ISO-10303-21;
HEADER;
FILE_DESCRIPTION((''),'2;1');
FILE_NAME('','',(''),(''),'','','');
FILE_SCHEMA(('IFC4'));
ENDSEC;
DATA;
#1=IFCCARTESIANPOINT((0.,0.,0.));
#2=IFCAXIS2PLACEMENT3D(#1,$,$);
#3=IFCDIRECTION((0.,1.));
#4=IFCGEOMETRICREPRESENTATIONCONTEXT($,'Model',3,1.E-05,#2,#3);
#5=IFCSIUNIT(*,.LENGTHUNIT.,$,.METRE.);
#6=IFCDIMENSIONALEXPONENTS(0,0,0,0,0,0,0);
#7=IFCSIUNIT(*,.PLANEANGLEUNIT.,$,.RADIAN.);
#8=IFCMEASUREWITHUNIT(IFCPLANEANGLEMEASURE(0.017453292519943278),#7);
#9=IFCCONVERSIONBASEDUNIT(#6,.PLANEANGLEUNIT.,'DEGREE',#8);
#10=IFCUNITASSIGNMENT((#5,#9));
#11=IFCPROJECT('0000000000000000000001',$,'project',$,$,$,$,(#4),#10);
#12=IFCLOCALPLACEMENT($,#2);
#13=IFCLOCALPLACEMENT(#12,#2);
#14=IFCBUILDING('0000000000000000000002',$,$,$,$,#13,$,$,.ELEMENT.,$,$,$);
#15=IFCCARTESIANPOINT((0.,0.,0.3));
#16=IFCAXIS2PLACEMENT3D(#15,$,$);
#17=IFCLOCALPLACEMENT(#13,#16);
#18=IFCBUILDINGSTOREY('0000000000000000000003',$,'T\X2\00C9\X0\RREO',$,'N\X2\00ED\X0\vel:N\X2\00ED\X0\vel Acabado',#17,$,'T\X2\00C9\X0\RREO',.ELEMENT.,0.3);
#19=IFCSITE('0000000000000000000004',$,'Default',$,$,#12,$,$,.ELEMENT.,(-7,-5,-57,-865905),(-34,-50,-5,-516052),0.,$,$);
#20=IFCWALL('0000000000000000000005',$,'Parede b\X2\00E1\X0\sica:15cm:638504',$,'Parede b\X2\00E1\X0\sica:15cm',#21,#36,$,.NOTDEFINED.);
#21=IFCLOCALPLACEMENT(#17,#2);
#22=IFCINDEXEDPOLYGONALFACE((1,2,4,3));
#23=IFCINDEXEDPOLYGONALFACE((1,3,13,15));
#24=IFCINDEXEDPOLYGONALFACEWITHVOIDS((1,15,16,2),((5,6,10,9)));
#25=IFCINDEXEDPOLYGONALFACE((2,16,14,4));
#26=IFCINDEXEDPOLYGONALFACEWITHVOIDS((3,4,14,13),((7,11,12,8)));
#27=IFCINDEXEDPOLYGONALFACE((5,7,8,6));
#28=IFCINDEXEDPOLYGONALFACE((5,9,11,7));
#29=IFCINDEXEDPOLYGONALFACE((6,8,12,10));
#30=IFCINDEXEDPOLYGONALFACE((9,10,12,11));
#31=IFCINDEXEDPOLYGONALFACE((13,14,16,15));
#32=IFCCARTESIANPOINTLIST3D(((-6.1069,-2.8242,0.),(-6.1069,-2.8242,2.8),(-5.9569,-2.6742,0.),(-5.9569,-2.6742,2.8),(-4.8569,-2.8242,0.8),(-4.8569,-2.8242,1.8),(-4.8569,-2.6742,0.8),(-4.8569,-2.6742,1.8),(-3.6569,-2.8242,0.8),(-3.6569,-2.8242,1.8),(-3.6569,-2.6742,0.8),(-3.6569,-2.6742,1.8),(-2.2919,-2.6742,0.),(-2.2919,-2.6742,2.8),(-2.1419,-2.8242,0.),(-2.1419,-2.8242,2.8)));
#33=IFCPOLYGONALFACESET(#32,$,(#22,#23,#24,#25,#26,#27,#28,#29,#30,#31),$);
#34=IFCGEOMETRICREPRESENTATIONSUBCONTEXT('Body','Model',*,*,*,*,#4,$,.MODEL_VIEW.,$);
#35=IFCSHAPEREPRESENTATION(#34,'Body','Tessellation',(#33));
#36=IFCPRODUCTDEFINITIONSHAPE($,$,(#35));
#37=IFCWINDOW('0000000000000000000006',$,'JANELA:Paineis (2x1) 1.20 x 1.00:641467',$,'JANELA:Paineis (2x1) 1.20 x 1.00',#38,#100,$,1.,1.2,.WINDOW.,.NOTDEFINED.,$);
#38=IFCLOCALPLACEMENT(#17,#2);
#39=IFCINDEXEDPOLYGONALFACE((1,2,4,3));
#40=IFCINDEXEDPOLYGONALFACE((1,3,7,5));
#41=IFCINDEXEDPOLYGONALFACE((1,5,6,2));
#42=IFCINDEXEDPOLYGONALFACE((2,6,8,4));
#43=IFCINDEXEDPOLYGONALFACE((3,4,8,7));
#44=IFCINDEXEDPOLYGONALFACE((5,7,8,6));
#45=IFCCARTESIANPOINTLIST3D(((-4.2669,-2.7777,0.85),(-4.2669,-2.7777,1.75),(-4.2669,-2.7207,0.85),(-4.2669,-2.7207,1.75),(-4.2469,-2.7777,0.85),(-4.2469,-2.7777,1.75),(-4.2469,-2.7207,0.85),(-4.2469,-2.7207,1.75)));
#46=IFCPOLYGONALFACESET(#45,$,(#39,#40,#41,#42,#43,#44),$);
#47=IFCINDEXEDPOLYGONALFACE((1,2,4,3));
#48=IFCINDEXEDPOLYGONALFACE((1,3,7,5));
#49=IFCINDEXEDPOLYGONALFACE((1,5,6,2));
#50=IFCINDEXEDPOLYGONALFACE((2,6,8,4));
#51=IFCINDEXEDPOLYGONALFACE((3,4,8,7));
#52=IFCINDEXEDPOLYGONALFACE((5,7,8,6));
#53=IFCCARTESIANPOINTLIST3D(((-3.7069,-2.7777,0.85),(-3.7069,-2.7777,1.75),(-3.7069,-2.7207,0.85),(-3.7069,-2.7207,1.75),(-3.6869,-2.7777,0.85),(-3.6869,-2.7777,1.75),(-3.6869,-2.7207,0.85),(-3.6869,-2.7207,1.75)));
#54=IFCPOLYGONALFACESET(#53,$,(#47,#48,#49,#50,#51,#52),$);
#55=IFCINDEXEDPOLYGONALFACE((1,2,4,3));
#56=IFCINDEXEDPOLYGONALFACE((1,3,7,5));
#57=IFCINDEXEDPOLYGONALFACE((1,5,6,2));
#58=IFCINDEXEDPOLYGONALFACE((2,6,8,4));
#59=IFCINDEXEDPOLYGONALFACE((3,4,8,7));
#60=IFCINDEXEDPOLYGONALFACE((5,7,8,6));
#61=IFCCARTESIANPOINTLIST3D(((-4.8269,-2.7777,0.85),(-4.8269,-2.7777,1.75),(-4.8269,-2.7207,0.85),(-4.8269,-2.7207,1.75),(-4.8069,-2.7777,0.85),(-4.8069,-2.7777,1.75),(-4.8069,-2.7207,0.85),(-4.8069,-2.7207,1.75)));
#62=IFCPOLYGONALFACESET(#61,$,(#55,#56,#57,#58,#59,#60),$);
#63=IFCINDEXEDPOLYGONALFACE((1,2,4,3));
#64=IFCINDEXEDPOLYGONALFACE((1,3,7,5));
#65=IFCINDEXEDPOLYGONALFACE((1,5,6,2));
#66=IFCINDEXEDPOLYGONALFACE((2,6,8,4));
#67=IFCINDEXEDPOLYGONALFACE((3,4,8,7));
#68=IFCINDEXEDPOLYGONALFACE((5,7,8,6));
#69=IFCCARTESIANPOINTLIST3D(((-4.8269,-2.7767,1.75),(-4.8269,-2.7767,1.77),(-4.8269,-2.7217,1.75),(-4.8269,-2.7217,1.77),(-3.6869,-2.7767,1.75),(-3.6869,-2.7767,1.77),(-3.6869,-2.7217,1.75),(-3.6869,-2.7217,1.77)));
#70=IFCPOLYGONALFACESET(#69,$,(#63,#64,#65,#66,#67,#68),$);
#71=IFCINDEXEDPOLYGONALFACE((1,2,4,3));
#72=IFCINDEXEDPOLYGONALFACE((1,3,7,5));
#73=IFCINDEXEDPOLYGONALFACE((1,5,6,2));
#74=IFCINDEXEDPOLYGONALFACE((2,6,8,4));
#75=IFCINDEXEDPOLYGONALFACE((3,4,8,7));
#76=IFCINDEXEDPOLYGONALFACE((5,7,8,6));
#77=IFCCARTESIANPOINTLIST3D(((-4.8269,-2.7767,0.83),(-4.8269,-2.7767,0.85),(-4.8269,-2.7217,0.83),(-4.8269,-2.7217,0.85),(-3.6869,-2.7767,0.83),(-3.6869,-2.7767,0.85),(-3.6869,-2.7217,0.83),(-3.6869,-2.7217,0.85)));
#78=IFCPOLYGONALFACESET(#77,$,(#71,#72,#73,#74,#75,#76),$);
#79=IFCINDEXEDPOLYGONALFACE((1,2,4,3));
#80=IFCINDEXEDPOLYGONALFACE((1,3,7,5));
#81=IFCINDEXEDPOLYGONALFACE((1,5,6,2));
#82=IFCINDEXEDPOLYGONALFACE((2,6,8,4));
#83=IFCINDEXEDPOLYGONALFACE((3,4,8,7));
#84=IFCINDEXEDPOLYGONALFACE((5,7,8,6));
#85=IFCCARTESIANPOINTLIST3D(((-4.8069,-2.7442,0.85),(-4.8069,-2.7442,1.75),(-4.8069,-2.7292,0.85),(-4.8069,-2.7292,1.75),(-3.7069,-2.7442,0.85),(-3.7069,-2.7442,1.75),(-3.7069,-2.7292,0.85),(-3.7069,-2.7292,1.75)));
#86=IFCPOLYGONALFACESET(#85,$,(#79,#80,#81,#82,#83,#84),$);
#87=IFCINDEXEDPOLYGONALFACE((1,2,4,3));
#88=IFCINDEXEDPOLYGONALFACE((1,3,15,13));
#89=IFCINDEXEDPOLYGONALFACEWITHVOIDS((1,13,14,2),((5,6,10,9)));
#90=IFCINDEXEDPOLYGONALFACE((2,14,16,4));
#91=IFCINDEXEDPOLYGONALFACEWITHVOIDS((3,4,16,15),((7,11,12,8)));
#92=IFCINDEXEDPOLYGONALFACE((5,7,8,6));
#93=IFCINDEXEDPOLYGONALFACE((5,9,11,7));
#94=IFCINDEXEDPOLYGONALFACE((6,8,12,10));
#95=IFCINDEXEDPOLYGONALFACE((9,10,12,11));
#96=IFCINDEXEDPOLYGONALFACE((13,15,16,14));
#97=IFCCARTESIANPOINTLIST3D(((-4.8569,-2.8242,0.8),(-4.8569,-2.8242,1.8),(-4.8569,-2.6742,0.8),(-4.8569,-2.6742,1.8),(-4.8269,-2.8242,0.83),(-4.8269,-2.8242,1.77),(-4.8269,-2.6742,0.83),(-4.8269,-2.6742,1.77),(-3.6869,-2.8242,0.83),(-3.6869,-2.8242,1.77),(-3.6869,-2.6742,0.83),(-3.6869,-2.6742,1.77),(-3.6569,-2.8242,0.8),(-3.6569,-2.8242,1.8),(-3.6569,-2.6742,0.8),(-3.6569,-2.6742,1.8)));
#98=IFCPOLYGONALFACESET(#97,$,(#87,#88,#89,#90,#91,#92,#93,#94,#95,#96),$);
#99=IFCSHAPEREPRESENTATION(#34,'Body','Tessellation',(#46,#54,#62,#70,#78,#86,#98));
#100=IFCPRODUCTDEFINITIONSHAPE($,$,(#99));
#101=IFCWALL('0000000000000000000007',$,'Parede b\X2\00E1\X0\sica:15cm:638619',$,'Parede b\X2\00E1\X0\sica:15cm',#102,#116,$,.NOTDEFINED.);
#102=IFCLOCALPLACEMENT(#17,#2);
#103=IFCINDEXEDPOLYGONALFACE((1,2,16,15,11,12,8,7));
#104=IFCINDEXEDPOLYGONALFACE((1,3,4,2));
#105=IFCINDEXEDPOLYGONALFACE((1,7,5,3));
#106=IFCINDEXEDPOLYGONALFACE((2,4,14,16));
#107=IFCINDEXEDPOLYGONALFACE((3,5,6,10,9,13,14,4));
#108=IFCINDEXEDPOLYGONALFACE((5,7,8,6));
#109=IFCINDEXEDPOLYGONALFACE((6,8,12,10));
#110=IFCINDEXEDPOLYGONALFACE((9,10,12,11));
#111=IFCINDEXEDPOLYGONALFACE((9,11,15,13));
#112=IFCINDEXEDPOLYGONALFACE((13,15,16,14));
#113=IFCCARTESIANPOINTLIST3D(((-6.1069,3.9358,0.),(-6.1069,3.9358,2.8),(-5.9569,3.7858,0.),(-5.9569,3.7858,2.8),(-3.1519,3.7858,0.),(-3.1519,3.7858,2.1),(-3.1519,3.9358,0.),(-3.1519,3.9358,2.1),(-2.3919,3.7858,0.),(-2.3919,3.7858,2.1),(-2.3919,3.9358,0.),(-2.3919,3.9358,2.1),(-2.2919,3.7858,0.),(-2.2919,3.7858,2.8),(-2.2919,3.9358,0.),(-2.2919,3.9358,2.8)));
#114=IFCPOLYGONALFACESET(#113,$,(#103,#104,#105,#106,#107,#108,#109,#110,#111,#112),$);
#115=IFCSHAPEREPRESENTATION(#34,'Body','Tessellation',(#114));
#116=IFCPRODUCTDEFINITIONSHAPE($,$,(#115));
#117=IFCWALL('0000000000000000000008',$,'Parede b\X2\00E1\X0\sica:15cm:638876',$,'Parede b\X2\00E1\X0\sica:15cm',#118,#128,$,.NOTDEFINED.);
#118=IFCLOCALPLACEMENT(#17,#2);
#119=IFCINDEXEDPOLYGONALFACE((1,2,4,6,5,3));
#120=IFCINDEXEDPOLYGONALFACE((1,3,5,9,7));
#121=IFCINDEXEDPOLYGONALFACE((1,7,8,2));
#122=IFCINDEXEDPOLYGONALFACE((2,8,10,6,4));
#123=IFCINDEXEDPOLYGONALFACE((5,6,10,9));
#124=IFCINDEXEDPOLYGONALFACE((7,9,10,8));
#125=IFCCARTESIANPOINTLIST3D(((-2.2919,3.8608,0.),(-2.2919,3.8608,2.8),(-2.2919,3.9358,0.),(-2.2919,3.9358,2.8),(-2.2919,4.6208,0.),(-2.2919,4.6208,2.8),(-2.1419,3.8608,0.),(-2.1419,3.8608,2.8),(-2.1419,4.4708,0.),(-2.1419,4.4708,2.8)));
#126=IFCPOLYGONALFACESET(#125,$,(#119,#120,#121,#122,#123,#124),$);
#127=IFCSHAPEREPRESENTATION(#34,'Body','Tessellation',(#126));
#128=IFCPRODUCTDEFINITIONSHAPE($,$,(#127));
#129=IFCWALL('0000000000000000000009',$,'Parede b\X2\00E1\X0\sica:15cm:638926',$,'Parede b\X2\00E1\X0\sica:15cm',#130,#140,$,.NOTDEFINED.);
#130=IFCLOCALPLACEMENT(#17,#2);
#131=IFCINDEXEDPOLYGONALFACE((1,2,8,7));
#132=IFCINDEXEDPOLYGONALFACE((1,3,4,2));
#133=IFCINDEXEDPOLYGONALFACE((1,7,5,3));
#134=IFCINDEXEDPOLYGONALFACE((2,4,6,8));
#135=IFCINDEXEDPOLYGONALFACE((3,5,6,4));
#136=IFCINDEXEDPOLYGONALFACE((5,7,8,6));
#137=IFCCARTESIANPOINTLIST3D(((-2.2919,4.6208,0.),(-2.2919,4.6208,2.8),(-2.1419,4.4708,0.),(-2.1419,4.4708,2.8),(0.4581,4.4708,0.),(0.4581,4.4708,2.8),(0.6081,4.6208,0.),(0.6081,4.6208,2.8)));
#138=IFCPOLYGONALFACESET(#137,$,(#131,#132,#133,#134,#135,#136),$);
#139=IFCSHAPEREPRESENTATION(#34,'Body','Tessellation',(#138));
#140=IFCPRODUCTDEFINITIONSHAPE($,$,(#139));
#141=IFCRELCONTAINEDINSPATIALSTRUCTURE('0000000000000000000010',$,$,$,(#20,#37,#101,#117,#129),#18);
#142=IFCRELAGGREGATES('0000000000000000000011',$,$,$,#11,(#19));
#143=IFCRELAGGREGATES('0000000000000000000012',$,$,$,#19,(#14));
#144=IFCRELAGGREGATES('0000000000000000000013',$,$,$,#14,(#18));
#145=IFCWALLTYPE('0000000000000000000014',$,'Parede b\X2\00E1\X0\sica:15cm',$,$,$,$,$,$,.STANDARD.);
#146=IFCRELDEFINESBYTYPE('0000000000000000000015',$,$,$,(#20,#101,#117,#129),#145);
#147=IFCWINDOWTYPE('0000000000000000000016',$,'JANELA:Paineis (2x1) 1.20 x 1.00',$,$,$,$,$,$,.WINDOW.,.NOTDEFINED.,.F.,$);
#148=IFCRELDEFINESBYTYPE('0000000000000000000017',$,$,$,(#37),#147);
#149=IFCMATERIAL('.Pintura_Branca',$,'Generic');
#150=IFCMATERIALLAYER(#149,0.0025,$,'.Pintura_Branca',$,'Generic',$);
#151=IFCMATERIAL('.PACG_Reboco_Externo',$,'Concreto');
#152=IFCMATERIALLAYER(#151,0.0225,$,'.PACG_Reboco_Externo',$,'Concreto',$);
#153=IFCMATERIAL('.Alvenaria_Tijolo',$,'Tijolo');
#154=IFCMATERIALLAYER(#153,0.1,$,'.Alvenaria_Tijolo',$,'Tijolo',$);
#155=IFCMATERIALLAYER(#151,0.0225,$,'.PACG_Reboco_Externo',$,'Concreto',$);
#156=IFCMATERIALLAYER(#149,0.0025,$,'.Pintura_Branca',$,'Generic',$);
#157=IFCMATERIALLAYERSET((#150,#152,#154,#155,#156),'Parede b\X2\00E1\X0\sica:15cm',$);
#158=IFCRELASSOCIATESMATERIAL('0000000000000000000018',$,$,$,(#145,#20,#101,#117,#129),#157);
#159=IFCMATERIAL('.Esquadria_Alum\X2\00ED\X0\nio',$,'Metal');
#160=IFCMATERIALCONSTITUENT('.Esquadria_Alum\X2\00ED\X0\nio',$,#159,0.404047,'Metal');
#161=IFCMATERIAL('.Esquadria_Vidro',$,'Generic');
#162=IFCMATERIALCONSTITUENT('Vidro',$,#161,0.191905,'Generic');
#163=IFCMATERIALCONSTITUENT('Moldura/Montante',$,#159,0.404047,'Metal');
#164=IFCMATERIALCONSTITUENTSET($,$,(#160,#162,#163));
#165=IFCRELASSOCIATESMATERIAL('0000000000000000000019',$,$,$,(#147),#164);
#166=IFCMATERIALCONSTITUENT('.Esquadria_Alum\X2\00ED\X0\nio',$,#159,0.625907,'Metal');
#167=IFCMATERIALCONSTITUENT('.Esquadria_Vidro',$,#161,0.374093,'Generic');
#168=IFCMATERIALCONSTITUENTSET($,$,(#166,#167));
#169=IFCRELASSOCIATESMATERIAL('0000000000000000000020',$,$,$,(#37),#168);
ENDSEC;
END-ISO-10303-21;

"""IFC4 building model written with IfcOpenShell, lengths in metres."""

from ifc_helpers import new_model, entity, si_unit, converted_unit, direction, frame, frame_2d, origin, origin_2d_with_axis, place, context, subcontext, project, spatial, polyline, rectangle, outline, extrude, source, transform, mapped, material, layer, layer_set, layer_usage, constituent, constituent_set, type_object, type_shapes, element, fill, save


model = new_model("IFC4")

# Units and contexts
model_context = context("Model", 3, precision=1e-05, world=origin(), true_north=direction((0.0, 1.0)))
body_context = subcontext(model_context, "Body", "Model", "MODEL_VIEW")
ifc_project = project(units=[si_unit("LENGTHUNIT", "METRE"), converted_unit("PLANEANGLEUNIT", "DEGREE", entity("IfcPlaneAngleMeasure", 0.017453292519943278), si_unit("PLANEANGLEUNIT", "RADIAN"), dimensions=[0, 0, 0, 0, 0, 0, 0])], contexts=[model_context])

# Site, building, storey
site_placement = place(None, origin())
site = spatial("IfcSite", under=ifc_project, at=site_placement, Name="Default", CompositionType="ELEMENT", RefLatitude=(-7, -5, -57, -865905), RefLongitude=(-34, -50, -5, -516052), RefElevation=0.0)
building_placement = place(site_placement, origin())
building = spatial("IfcBuilding", under=site, at=building_placement, CompositionType="ELEMENT")
storey_placement = place(building_placement, frame((0.0, 0.0, 0.3)))
storey = spatial("IfcBuildingStorey", under=building, at=storey_placement, Name="TÉRREO", ObjectType="Nível:Nível Acabado", LongName="TÉRREO", CompositionType="ELEMENT", Elevation=0.3)

# Shared definitions
ifc_material_1 = material(Name=".Pintura_Branca", Category="Generic")
ifc_layer_1 = layer(ifc_material_1, 0.0025, Name=".Pintura_Branca", Category="Generic")
ifc_material_2 = material(Name=".PACG_Reboco_Externo", Category="Concreto")
ifc_layer_2 = layer(ifc_material_2, 0.0225, Name=".PACG_Reboco_Externo", Category="Concreto")
ifc_material_3 = material(Name=".Alvenaria_Tijolo", Category="Tijolo")
ifc_layer_3 = layer(ifc_material_3, 0.1, Name=".Alvenaria_Tijolo", Category="Tijolo")
ifc_layer_4 = layer(ifc_material_2, 0.0225, Name=".PACG_Reboco_Externo", Category="Concreto")
ifc_layer_5 = layer(ifc_material_1, 0.0025, Name=".Pintura_Branca", Category="Generic")
ifc_layer_set_1 = layer_set([ifc_layer_1, ifc_layer_2, ifc_layer_3, ifc_layer_4, ifc_layer_5], Name="Parede básica:15cm")
wall_type = type_object("IfcWallType", Name="Parede básica:15cm", PredefinedType="STANDARD", material=ifc_layer_set_1)
ifc_material_4 = material(Name=".Esquadria_Alumínio", Category="Metal")
ifc_material_5 = material(Name=".Esquadria_Vidro", Category="Generic")
ifc_constituent_1 = constituent(ifc_material_4, Name=".Esquadria_Alumínio", Category="Metal", fraction=0.404047)
ifc_constituent_2 = constituent(ifc_material_5, Name="Vidro", Category="Generic", fraction=0.191905)
ifc_constituent_3 = constituent(ifc_material_4, Name="Moldura/Montante", Category="Metal", fraction=0.404047)
ifc_constituent_set_1 = constituent_set(constituents=[ifc_constituent_1, ifc_constituent_2, ifc_constituent_3])
window_type_1 = type_object("IfcWindowType", Name="JANELA:Paineis (2x1) 1.20 x 1.00", ParameterTakesPrecedence=False, PartitioningType="NOTDEFINED", PredefinedType="WINDOW", material=ifc_constituent_set_1)
shared_shape_1 = source(origin(), body_context, "Body", "SweptSolid", [
    extrude(rectangle(XDim=0.02, YDim=0.057, at=origin_2d_with_axis()), frame((0.6, 0.075, 0.05), z_axis=(0.0, 0.0, 1.0), x_axis=(-1.0, 0.0, 0.0)), (0.0, 0.0, 1.0), 0.9),
    extrude(rectangle(XDim=0.02, YDim=0.057, at=frame_2d((0.0, 0.0), x_axis=(1.0, 0.0))), frame((0.04, 0.075, 0.05), z_axis=(0.0, 0.0, 1.0), x_axis=(-1.0, 0.0, 0.0)), (0.0, 0.0, 1.0), 0.9),
    extrude(rectangle(XDim=0.02, YDim=0.057, at=frame_2d((0.0, 0.0), x_axis=(1.0, 0.0))), frame((1.16, 0.075, 0.05), z_axis=(0.0, 0.0, 1.0), x_axis=(-1.0, 0.0, 0.0)), (0.0, 0.0, 1.0), 0.9),
    extrude(rectangle(XDim=1.14, YDim=0.055, at=frame_2d((0.0, 0.0), x_axis=(1.0, 0.0))), frame((0.6, 0.075, 0.95), z_axis=(0.0, 0.0, 1.0), x_axis=(-1.0, 0.0, 0.0)), (0.0, 0.0, 1.0), 0.02),
    extrude(rectangle(XDim=1.14, YDim=0.055, at=frame_2d((0.0, 0.0), x_axis=(1.0, 0.0))), frame((0.6, 0.075, 0.03), z_axis=(0.0, 0.0, 1.0), x_axis=(-1.0, 0.0, 0.0)), (0.0, 0.0, 1.0), 0.02),
    extrude(rectangle(XDim=0.015, YDim=1.1, at=frame_2d((0.0, 0.0), x_axis=(1.0, 0.0))), frame((0.6, 0.0625, 0.05), z_axis=(0.0, 0.0, 1.0), x_axis=(0.0, 1.0, 0.0)), (0.0, 0.0, 1.0), 0.9),
    extrude(outline(polyline([(-0.6, -0.5), (0.6, -0.5), (0.6, 0.5), (-0.6, 0.5), (-0.6, -0.5)]), holes=[polyline([(0.57, -0.47), (-0.57, -0.47), (-0.57, 0.47), (0.57, 0.47), (0.57, -0.47)])]), frame((0.6, 0.0, 0.5), z_axis=(0.0, 1.0, 0.0), x_axis=(1.0, 0.0, 0.0)), (0.0, 0.0, 1.0), 0.15),
])
type_shapes(window_type_1, [shared_shape_1])

# Wall, opening, window
ifc_layer_usage_1 = layer_usage(ifc_layer_set_1, "AXIS2", "NEGATIVE", 0.075)
wall_1_placement = place(storey_placement, frame((-6.1069, -2.7492, 0.0)))
wall_1 = element("IfcWall", 1, at=wall_1_placement, inside=storey, type_object=wall_type, material=ifc_layer_usage_1, Name="Parede básica:15cm:638504", ObjectType="Parede básica:15cm", PredefinedType="NOTDEFINED", context=body_context, shape_type="SweptSolid", body=[
    extrude(outline(polyline([(3.965, -0.075), (3.815, 0.075), (0.15, 0.075), (0.0, -0.075), (3.965, -0.075)])), origin(), (0.0, 0.0, 1.0), 2.8),
])
opening_1_placement = place(wall_1_placement, frame((2.45, 0.075, 0.8)))
opening_1 = element("IfcOpeningElement", 2, at=opening_1_placement, cuts=wall_1, PredefinedType="OPENING", context=body_context, shape_type="SweptSolid", body=[
    extrude(rectangle(XDim=1.0, YDim=1.2, at=frame_2d((0.5, 0.6), x_axis=(1.0, 0.0))), frame((0.0, 0.0, 0.0), z_axis=(0.0, -1.0, 0.0), x_axis=(0.0, 0.0, 1.0)), (0.0, 0.0, 1.0), 0.15),
])
ifc_constituent_4 = constituent(ifc_material_4, Name=".Esquadria_Alumínio", Category="Metal", fraction=0.625907)
ifc_constituent_5 = constituent(ifc_material_5, Name=".Esquadria_Vidro", Category="Generic", fraction=0.374093)
ifc_constituent_set_2 = constituent_set(constituents=[ifc_constituent_4, ifc_constituent_5])
window_1_placement = place(opening_1_placement, frame((0.0, 0.0, 0.0), z_axis=(0.0, 0.0, 1.0), x_axis=(-1.0, 0.0, 0.0)))
window_1 = element("IfcWindow", 3, at=window_1_placement, inside=storey, type_object=window_type_1, material=ifc_constituent_set_2, Name="JANELA:Paineis (2x1) 1.20 x 1.00:641467", ObjectType="JANELA:Paineis (2x1) 1.20 x 1.00", OverallHeight=1.0, OverallWidth=1.2, PartitioningType="NOTDEFINED", PredefinedType="WINDOW", context=body_context, shape_type="MappedRepresentation", body=[
    mapped(shared_shape_1, transform((0.0, 0.0, 0.0), scale=1.0)),
])
fill(opening_1, window_1)

# Wall, opening
ifc_layer_usage_2 = layer_usage(ifc_layer_set_1, "AXIS2", "NEGATIVE", 0.075)
wall_2_placement = place(storey_placement, frame((-6.1069, 3.8608, 0.0)))
wall_2 = element("IfcWall", 4, at=wall_2_placement, inside=storey, type_object=wall_type, material=ifc_layer_usage_2, Name="Parede básica:15cm:638619", ObjectType="Parede básica:15cm", PredefinedType="NOTDEFINED", context=body_context, shape_type="SweptSolid", body=[
    extrude(outline(polyline([(0.15, -0.075), (2.53, -0.075), (2.68, -0.075), (3.815, -0.075), (3.815, 0.0), (3.815, 0.075), (0.0, 0.075), (0.15, -0.075)])), origin(), (0.0, 0.0, 1.0), 2.8),
])
opening_2_placement = place(wall_2_placement, frame((2.955, -0.075, 0.0)))
element("IfcOpeningElement", 5, at=opening_2_placement, cuts=wall_2, PredefinedType="OPENING", context=body_context, shape_type="SweptSolid", body=[
    extrude(rectangle(XDim=0.76, YDim=2.1, at=frame_2d((1.05, 0.38), x_axis=(0.0, 1.0))), frame((0.0, 0.0, 0.0), z_axis=(0.0, 1.0, 0.0), x_axis=(0.0, 0.0, 1.0)), (0.0, 0.0, 1.0), 0.15),
])

# Walls
ifc_layer_usage_3 = layer_usage(ifc_layer_set_1, "AXIS2", "NEGATIVE", 0.075)
wall_3_placement = place(storey_placement, frame((-2.2169, 3.8608, 0.0), z_axis=(0.0, 0.0, 1.0), x_axis=(0.0, 1.0, 0.0)))
element("IfcWall", 6, at=wall_3_placement, inside=storey, type_object=wall_type, material=ifc_layer_usage_3, Name="Parede básica:15cm:638876", ObjectType="Parede básica:15cm", PredefinedType="NOTDEFINED", context=body_context, shape_type="SweptSolid", body=[
    extrude(outline(polyline([(0.61, -0.075), (0.76, 0.075), (0.075, 0.075), (0.0, 0.075), (0.0, -0.075), (0.61, -0.075)])), origin(), (0.0, 0.0, 1.0), 2.8),
])
ifc_layer_usage_4 = layer_usage(ifc_layer_set_1, "AXIS2", "NEGATIVE", 0.075)
wall_4_placement = place(storey_placement, frame((-2.2919, 4.5458, 0.0)))
element("IfcWall", 7, at=wall_4_placement, inside=storey, type_object=wall_type, material=ifc_layer_usage_4, Name="Parede básica:15cm:638926", ObjectType="Parede básica:15cm", PredefinedType="NOTDEFINED", context=body_context, shape_type="SweptSolid", body=[
    extrude(outline(polyline([(2.75, -0.075), (2.9, 0.075), (0.0, 0.075), (0.15, -0.075), (2.75, -0.075)])), origin(), (0.0, 0.0, 1.0), 2.8),
])

save(model, "model.ifc")
